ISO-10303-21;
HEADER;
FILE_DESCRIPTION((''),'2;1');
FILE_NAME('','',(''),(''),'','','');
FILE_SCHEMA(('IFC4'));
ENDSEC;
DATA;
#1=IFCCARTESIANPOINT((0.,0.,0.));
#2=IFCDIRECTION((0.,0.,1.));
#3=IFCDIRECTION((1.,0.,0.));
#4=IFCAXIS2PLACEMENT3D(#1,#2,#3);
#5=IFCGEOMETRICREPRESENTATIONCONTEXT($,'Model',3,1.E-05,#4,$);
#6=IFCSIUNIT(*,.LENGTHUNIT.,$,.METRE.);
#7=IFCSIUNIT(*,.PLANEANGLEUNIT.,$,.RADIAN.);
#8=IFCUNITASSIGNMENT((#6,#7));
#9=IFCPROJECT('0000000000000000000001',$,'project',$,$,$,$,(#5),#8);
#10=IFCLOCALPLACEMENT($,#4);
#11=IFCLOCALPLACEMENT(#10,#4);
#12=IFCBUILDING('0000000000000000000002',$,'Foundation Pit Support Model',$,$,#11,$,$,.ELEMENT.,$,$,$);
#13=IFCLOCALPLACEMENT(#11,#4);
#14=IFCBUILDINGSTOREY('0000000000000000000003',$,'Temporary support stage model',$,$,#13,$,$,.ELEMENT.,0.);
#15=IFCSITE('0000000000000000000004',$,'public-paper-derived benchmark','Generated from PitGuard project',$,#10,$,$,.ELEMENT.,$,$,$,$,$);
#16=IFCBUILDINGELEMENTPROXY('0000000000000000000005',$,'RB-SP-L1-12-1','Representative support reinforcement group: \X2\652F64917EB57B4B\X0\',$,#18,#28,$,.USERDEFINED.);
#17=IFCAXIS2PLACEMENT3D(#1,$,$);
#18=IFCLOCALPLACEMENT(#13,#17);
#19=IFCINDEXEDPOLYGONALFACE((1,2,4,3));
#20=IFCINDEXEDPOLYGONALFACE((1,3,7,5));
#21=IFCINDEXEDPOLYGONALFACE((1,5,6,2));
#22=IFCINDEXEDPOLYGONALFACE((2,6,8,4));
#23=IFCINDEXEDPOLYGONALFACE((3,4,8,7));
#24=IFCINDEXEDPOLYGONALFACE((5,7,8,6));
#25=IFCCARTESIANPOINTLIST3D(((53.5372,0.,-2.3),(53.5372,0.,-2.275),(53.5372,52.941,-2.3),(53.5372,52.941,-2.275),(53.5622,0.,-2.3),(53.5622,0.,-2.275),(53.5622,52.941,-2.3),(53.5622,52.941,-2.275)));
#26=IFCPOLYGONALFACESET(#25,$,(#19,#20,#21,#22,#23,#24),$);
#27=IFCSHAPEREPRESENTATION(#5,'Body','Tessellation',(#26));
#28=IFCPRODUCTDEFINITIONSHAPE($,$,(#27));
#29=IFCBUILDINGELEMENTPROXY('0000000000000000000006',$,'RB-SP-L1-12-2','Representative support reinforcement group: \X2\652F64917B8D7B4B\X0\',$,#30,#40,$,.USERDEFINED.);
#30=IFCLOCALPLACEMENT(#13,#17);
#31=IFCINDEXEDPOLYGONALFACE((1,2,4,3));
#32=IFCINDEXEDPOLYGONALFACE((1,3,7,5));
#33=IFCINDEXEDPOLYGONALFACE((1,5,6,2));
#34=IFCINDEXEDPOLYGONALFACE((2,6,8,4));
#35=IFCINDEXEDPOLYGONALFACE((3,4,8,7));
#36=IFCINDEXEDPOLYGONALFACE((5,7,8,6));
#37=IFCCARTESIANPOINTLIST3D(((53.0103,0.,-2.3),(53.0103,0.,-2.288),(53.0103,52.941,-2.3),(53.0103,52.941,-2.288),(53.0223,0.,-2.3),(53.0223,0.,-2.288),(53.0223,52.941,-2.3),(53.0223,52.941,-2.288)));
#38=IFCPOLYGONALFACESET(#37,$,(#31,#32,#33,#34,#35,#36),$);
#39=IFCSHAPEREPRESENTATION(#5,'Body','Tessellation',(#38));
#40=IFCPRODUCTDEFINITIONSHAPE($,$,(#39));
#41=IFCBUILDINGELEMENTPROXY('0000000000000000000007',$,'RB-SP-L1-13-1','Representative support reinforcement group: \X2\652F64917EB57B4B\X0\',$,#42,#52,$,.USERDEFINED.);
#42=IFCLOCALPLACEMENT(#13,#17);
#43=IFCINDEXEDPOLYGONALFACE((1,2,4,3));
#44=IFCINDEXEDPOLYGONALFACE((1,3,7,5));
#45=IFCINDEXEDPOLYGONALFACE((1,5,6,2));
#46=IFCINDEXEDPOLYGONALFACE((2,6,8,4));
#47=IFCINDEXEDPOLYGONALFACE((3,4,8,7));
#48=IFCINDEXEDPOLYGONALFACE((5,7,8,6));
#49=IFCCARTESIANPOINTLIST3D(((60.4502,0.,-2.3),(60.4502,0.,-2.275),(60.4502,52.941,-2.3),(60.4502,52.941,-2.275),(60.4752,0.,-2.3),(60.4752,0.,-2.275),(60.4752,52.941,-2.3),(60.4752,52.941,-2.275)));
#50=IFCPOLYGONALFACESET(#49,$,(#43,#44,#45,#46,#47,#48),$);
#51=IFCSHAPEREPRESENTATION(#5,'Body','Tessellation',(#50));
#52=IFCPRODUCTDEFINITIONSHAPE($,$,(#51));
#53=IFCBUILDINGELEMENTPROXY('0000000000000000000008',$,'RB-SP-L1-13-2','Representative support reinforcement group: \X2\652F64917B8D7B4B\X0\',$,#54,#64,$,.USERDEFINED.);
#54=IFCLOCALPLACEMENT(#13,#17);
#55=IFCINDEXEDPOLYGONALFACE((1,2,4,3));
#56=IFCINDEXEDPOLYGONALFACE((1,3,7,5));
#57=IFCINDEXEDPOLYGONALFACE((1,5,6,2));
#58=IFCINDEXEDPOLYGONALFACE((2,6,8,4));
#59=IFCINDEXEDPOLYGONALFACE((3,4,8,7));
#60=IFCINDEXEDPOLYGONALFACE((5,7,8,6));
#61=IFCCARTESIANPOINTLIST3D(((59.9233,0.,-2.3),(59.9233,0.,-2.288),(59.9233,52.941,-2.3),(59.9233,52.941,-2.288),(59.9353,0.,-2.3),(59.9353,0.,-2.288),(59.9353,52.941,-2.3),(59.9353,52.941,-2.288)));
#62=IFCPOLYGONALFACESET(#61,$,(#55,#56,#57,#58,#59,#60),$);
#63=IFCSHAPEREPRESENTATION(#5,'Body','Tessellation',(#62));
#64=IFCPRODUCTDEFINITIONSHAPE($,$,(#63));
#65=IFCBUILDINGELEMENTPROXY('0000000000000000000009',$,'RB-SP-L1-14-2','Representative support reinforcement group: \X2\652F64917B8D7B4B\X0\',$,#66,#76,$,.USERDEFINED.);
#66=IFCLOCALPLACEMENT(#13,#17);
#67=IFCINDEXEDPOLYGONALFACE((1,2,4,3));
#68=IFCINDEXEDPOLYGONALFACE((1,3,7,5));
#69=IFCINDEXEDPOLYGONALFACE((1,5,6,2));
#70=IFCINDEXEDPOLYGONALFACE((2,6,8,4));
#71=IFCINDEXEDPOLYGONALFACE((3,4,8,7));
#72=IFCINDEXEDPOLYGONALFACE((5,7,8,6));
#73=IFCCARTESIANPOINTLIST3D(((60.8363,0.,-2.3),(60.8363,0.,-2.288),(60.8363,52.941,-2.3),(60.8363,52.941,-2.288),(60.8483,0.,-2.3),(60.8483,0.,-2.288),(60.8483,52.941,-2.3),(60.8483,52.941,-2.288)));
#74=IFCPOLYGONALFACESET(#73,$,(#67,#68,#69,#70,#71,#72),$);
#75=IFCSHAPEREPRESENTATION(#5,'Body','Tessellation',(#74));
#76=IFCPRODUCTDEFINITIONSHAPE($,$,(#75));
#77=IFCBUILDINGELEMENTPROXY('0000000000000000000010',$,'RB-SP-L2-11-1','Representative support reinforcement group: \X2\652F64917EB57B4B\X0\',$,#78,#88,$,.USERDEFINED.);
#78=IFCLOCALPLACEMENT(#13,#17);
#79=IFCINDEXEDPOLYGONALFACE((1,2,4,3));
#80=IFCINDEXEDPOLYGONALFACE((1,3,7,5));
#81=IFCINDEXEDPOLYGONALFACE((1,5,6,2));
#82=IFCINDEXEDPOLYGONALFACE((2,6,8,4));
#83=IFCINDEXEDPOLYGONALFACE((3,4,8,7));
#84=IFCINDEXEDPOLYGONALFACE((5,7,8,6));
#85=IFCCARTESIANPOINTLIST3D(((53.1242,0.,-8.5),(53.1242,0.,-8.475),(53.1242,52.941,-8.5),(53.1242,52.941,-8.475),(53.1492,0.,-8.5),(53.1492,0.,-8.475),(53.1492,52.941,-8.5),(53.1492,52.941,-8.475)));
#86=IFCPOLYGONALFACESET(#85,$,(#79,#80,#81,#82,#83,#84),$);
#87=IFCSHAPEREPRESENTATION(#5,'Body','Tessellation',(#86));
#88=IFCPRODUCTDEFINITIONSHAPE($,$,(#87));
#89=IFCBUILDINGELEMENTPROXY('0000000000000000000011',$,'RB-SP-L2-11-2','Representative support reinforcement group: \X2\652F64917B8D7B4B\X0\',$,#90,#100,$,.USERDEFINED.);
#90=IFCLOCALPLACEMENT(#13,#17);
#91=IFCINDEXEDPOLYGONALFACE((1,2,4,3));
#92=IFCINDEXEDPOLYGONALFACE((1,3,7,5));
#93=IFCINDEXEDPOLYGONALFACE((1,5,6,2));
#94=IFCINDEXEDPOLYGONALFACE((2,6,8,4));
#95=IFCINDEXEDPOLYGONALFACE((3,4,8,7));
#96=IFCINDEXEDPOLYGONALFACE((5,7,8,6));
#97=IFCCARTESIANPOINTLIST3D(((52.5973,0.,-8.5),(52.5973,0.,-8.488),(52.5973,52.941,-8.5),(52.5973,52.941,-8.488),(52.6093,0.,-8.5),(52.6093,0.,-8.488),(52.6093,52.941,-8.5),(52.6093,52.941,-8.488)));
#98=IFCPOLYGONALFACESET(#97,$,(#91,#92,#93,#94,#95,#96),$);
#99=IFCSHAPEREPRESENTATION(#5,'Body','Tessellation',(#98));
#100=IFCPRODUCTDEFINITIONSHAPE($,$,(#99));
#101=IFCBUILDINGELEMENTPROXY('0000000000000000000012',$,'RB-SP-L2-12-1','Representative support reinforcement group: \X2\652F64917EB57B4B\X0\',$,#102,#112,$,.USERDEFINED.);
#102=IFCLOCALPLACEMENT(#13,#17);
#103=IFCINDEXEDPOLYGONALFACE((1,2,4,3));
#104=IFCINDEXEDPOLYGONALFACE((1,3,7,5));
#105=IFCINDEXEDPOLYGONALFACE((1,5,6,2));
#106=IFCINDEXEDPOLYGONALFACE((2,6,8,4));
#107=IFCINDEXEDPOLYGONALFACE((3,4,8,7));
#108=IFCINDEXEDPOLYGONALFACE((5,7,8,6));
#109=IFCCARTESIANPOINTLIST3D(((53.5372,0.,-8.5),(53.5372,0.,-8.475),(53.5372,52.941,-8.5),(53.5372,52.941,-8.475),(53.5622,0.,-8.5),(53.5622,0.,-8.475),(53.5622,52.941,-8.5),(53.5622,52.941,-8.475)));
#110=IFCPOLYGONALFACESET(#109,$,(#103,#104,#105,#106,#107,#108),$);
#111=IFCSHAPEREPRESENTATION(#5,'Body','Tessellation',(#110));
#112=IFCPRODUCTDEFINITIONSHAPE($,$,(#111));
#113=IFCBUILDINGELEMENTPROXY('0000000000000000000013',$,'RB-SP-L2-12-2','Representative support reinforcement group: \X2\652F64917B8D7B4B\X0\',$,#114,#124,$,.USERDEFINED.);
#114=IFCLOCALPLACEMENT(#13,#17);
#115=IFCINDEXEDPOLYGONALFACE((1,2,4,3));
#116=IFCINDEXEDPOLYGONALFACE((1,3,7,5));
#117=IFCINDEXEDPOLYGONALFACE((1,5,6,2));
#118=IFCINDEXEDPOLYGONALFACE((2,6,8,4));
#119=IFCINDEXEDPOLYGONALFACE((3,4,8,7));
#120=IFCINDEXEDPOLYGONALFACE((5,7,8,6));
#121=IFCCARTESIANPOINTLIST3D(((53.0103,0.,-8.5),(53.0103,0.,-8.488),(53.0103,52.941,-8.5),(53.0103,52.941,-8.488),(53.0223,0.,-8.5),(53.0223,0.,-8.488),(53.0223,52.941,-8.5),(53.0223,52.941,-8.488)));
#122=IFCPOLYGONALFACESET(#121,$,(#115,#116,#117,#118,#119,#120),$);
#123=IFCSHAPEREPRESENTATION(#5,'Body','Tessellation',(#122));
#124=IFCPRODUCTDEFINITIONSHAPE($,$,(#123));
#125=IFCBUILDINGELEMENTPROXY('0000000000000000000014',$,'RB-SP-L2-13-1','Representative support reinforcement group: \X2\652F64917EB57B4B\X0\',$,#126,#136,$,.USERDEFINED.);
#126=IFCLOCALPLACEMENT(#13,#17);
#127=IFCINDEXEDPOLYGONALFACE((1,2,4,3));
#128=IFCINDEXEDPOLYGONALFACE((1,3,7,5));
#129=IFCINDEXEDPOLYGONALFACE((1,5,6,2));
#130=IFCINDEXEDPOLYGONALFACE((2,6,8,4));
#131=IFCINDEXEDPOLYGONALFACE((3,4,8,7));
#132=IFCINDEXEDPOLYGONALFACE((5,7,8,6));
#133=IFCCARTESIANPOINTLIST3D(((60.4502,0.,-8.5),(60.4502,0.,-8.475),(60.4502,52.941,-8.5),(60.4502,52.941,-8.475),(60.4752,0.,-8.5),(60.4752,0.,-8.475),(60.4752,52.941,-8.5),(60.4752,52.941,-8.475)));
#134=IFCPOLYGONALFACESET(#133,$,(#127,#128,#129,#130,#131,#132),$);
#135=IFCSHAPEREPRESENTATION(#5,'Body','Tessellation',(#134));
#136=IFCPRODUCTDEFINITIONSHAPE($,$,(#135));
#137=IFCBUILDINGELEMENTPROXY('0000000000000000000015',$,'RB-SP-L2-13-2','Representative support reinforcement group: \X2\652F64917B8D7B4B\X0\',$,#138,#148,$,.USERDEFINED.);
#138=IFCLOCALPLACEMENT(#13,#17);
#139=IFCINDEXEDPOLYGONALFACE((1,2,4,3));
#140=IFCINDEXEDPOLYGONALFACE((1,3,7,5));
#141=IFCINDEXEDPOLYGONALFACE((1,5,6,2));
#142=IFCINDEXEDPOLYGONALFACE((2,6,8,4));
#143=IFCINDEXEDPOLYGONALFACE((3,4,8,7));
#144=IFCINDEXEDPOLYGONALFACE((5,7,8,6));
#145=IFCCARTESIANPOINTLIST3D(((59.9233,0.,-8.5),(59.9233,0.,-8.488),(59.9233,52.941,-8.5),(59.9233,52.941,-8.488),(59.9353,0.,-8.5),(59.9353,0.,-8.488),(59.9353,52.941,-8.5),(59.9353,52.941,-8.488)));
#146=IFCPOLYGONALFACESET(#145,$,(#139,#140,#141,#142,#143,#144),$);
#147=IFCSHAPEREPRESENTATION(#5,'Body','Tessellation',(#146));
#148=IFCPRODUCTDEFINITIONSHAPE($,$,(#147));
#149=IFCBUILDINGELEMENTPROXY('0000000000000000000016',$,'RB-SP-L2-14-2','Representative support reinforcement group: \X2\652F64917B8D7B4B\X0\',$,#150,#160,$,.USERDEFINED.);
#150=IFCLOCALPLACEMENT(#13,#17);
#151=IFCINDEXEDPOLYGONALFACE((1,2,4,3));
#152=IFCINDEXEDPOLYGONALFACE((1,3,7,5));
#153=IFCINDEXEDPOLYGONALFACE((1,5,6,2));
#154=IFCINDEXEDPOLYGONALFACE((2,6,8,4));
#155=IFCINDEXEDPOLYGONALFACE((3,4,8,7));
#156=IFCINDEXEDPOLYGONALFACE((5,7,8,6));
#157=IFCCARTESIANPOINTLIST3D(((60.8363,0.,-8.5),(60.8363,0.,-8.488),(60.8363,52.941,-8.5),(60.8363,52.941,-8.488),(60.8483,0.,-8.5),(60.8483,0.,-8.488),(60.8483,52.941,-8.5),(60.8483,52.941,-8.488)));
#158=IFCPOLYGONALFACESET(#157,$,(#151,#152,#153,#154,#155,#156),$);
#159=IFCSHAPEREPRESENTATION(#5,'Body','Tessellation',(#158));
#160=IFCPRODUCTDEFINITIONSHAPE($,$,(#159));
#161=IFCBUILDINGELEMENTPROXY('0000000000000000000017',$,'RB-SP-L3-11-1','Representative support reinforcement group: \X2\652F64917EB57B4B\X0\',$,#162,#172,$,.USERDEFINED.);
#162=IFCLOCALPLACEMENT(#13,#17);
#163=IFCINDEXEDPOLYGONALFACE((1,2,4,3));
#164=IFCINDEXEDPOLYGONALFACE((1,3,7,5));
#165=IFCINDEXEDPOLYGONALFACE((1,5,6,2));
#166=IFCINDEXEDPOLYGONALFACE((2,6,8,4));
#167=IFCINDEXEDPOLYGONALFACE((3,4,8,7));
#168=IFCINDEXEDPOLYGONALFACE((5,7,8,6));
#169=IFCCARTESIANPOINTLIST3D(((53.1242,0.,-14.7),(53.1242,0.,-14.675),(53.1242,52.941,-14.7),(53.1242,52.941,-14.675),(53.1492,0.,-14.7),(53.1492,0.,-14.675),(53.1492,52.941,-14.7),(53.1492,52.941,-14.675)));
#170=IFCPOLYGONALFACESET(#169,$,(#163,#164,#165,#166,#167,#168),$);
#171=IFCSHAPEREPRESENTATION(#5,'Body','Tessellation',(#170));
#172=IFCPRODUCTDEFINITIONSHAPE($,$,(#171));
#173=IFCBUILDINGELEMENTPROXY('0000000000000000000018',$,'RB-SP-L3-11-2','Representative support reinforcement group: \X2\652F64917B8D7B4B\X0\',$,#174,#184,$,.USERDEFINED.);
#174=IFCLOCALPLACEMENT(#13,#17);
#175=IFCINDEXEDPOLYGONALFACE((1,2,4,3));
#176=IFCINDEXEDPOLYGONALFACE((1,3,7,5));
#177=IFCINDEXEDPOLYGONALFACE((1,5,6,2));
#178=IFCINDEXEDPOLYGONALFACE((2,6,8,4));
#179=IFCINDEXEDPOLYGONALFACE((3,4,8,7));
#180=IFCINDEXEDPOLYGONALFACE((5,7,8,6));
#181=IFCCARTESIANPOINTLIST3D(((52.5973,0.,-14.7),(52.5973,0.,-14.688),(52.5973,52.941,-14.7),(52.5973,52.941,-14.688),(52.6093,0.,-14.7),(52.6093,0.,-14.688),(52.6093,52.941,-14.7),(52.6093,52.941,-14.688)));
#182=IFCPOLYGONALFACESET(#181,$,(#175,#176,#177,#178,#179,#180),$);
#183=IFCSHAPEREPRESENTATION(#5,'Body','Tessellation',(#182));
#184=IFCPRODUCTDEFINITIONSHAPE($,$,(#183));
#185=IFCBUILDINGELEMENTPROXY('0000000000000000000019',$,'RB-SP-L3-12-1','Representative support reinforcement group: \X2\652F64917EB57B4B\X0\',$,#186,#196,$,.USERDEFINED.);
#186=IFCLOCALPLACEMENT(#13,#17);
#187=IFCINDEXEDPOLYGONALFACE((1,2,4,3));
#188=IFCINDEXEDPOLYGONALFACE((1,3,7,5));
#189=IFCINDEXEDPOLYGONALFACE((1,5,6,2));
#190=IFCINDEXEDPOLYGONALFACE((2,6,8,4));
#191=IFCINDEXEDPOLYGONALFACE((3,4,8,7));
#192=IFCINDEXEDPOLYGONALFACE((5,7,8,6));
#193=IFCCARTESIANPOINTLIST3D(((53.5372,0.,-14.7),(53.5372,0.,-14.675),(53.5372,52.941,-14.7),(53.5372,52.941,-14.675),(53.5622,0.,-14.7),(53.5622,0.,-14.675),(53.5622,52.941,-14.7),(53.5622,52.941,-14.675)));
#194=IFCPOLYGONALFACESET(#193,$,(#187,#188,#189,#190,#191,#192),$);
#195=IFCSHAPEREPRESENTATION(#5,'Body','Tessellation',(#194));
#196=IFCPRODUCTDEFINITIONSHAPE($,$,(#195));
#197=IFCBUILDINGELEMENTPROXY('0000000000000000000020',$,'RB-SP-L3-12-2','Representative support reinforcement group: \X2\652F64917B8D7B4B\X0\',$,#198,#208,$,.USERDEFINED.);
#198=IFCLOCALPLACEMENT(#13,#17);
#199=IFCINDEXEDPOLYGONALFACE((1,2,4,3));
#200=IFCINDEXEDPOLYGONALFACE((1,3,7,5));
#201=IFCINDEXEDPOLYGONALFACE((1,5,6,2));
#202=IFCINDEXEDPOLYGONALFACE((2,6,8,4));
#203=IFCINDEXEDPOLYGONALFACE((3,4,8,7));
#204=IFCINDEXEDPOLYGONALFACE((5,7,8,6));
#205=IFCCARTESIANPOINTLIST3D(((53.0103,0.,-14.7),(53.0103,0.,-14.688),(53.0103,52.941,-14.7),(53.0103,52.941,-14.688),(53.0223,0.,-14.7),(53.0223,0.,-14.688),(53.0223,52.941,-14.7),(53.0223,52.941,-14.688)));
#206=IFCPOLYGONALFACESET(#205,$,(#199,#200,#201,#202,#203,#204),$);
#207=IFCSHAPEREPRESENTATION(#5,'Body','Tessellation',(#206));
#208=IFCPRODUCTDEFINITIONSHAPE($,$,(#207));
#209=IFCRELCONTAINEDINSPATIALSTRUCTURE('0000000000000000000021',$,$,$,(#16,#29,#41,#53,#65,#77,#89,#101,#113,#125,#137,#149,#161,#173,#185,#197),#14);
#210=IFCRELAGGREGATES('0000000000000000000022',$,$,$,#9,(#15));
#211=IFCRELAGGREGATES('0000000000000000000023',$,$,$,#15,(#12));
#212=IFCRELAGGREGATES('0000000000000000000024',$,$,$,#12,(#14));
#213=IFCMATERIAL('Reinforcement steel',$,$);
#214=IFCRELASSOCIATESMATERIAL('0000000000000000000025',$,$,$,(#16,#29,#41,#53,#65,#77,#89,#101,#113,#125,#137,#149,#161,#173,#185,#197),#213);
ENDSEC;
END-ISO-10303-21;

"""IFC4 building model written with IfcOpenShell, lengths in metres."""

from ifc_helpers import new_model, si_unit, frame, origin_with_axes, origin_2d, place, context, project, spatial, rectangle, extrude, material, element, save


model = new_model("IFC4")

# Units and contexts
model_context = context("Model", 3, precision=1e-05, world=origin_with_axes())
ifc_project = project(units=[si_unit("LENGTHUNIT", "METRE"), si_unit("PLANEANGLEUNIT", "RADIAN")], contexts=[model_context])

# Site, building, storey
site_placement = place(None, origin_with_axes())
site = spatial("IfcSite", under=ifc_project, at=site_placement, Name="public-paper-derived benchmark", Description="Generated from PitGuard project", CompositionType="ELEMENT")
building_placement = place(site_placement, origin_with_axes())
building = spatial("IfcBuilding", under=site, at=building_placement, Name="Foundation Pit Support Model", CompositionType="ELEMENT")
storey_placement = place(building_placement, origin_with_axes())
storey = spatial("IfcBuildingStorey", under=building, at=storey_placement, Name="Temporary support stage model", CompositionType="ELEMENT", Elevation=0.0)

# Building element proxies
ifc_material_1 = material(Name="Reinforcement steel")
proxy_1_placement = place(storey_placement, frame((53.5497, 26.4705, -2.3), z_axis=(0.0, 0.0, 1.0), x_axis=(0.0, 1.0, 0.0)))
element("IfcBuildingElementProxy", 1, at=proxy_1_placement, inside=storey, material=ifc_material_1, Name="RB-SP-L1-12-1", Description="Representative support reinforcement group: 支撑纵筋", PredefinedType="USERDEFINED", context=model_context, shape_type="SweptSolid", body=[
    extrude(rectangle(XDim=52.941, YDim=0.025, at=origin_2d()), origin_with_axes(), (0.0, 0.0, 1.0), 0.025),
])
proxy_2_placement = place(storey_placement, frame((53.0163, 26.4705, -2.3), z_axis=(0.0, 0.0, 1.0), x_axis=(0.0, 1.0, 0.0)))
element("IfcBuildingElementProxy", 2, at=proxy_2_placement, inside=storey, material=ifc_material_1, Name="RB-SP-L1-12-2", Description="Representative support reinforcement group: 支撑箍筋", PredefinedType="USERDEFINED", context=model_context, shape_type="SweptSolid", body=[
    extrude(rectangle(XDim=52.941, YDim=0.012, at=origin_2d()), origin_with_axes(), (0.0, 0.0, 1.0), 0.012),
])
proxy_3_placement = place(storey_placement, frame((60.4627, 26.4705, -2.3), z_axis=(0.0, 0.0, 1.0), x_axis=(0.0, 1.0, 0.0)))
element("IfcBuildingElementProxy", 3, at=proxy_3_placement, inside=storey, material=ifc_material_1, Name="RB-SP-L1-13-1", Description="Representative support reinforcement group: 支撑纵筋", PredefinedType="USERDEFINED", context=model_context, shape_type="SweptSolid", body=[
    extrude(rectangle(XDim=52.941, YDim=0.025, at=origin_2d()), origin_with_axes(), (0.0, 0.0, 1.0), 0.025),
])
for number, where, z_axis, x_axis, name in (
    (4, (59.9293, 26.4705, -2.3), (0.0, 0.0, 1.0), (0.0, 1.0, 0.0), "RB-SP-L1-13-2"),
    (5, (60.8423, 26.4705, -2.3), (0.0, 0.0, 1.0), (0.0, 1.0, 0.0), "RB-SP-L1-14-2"),
):
    element("IfcBuildingElementProxy", number, at=place(storey_placement, frame(where, z_axis=z_axis, x_axis=x_axis)), inside=storey, material=ifc_material_1, Name=name, Description="Representative support reinforcement group: 支撑箍筋", PredefinedType="USERDEFINED", context=model_context, shape_type="SweptSolid", body=[
        extrude(rectangle(XDim=52.941, YDim=0.012, at=origin_2d()), origin_with_axes(), (0.0, 0.0, 1.0), 0.012),
    ])
proxy_4_placement = place(storey_placement, frame((53.1367, 26.4705, -8.5), z_axis=(0.0, 0.0, 1.0), x_axis=(0.0, 1.0, 0.0)))
element("IfcBuildingElementProxy", 6, at=proxy_4_placement, inside=storey, material=ifc_material_1, Name="RB-SP-L2-11-1", Description="Representative support reinforcement group: 支撑纵筋", PredefinedType="USERDEFINED", context=model_context, shape_type="SweptSolid", body=[
    extrude(rectangle(XDim=52.941, YDim=0.025, at=origin_2d()), origin_with_axes(), (0.0, 0.0, 1.0), 0.025),
])
proxy_5_placement = place(storey_placement, frame((52.6033, 26.4705, -8.5), z_axis=(0.0, 0.0, 1.0), x_axis=(0.0, 1.0, 0.0)))
element("IfcBuildingElementProxy", 7, at=proxy_5_placement, inside=storey, material=ifc_material_1, Name="RB-SP-L2-11-2", Description="Representative support reinforcement group: 支撑箍筋", PredefinedType="USERDEFINED", context=model_context, shape_type="SweptSolid", body=[
    extrude(rectangle(XDim=52.941, YDim=0.012, at=origin_2d()), origin_with_axes(), (0.0, 0.0, 1.0), 0.012),
])
proxy_6_placement = place(storey_placement, frame((53.5497, 26.4705, -8.5), z_axis=(0.0, 0.0, 1.0), x_axis=(0.0, 1.0, 0.0)))
element("IfcBuildingElementProxy", 8, at=proxy_6_placement, inside=storey, material=ifc_material_1, Name="RB-SP-L2-12-1", Description="Representative support reinforcement group: 支撑纵筋", PredefinedType="USERDEFINED", context=model_context, shape_type="SweptSolid", body=[
    extrude(rectangle(XDim=52.941, YDim=0.025, at=origin_2d()), origin_with_axes(), (0.0, 0.0, 1.0), 0.025),
])
proxy_7_placement = place(storey_placement, frame((53.0163, 26.4705, -8.5), z_axis=(0.0, 0.0, 1.0), x_axis=(0.0, 1.0, 0.0)))
element("IfcBuildingElementProxy", 9, at=proxy_7_placement, inside=storey, material=ifc_material_1, Name="RB-SP-L2-12-2", Description="Representative support reinforcement group: 支撑箍筋", PredefinedType="USERDEFINED", context=model_context, shape_type="SweptSolid", body=[
    extrude(rectangle(XDim=52.941, YDim=0.012, at=origin_2d()), origin_with_axes(), (0.0, 0.0, 1.0), 0.012),
])
proxy_8_placement = place(storey_placement, frame((60.4627, 26.4705, -8.5), z_axis=(0.0, 0.0, 1.0), x_axis=(0.0, 1.0, 0.0)))
element("IfcBuildingElementProxy", 10, at=proxy_8_placement, inside=storey, material=ifc_material_1, Name="RB-SP-L2-13-1", Description="Representative support reinforcement group: 支撑纵筋", PredefinedType="USERDEFINED", context=model_context, shape_type="SweptSolid", body=[
    extrude(rectangle(XDim=52.941, YDim=0.025, at=origin_2d()), origin_with_axes(), (0.0, 0.0, 1.0), 0.025),
])
for number, where, z_axis, x_axis, name in (
    (11, (59.9293, 26.4705, -8.5), (0.0, 0.0, 1.0), (0.0, 1.0, 0.0), "RB-SP-L2-13-2"),
    (12, (60.8423, 26.4705, -8.5), (0.0, 0.0, 1.0), (0.0, 1.0, 0.0), "RB-SP-L2-14-2"),
):
    element("IfcBuildingElementProxy", number, at=place(storey_placement, frame(where, z_axis=z_axis, x_axis=x_axis)), inside=storey, material=ifc_material_1, Name=name, Description="Representative support reinforcement group: 支撑箍筋", PredefinedType="USERDEFINED", context=model_context, shape_type="SweptSolid", body=[
        extrude(rectangle(XDim=52.941, YDim=0.012, at=origin_2d()), origin_with_axes(), (0.0, 0.0, 1.0), 0.012),
    ])
proxy_9_placement = place(storey_placement, frame((53.1367, 26.4705, -14.7), z_axis=(0.0, 0.0, 1.0), x_axis=(0.0, 1.0, 0.0)))
element("IfcBuildingElementProxy", 13, at=proxy_9_placement, inside=storey, material=ifc_material_1, Name="RB-SP-L3-11-1", Description="Representative support reinforcement group: 支撑纵筋", PredefinedType="USERDEFINED", context=model_context, shape_type="SweptSolid", body=[
    extrude(rectangle(XDim=52.941, YDim=0.025, at=origin_2d()), origin_with_axes(), (0.0, 0.0, 1.0), 0.025),
])
proxy_10_placement = place(storey_placement, frame((52.6033, 26.4705, -14.7), z_axis=(0.0, 0.0, 1.0), x_axis=(0.0, 1.0, 0.0)))
element("IfcBuildingElementProxy", 14, at=proxy_10_placement, inside=storey, material=ifc_material_1, Name="RB-SP-L3-11-2", Description="Representative support reinforcement group: 支撑箍筋", PredefinedType="USERDEFINED", context=model_context, shape_type="SweptSolid", body=[
    extrude(rectangle(XDim=52.941, YDim=0.012, at=origin_2d()), origin_with_axes(), (0.0, 0.0, 1.0), 0.012),
])
proxy_11_placement = place(storey_placement, frame((53.5497, 26.4705, -14.7), z_axis=(0.0, 0.0, 1.0), x_axis=(0.0, 1.0, 0.0)))
element("IfcBuildingElementProxy", 15, at=proxy_11_placement, inside=storey, material=ifc_material_1, Name="RB-SP-L3-12-1", Description="Representative support reinforcement group: 支撑纵筋", PredefinedType="USERDEFINED", context=model_context, shape_type="SweptSolid", body=[
    extrude(rectangle(XDim=52.941, YDim=0.025, at=origin_2d()), origin_with_axes(), (0.0, 0.0, 1.0), 0.025),
])
proxy_12_placement = place(storey_placement, frame((53.0163, 26.4705, -14.7), z_axis=(0.0, 0.0, 1.0), x_axis=(0.0, 1.0, 0.0)))
element("IfcBuildingElementProxy", 16, at=proxy_12_placement, inside=storey, material=ifc_material_1, Name="RB-SP-L3-12-2", Description="Representative support reinforcement group: 支撑箍筋", PredefinedType="USERDEFINED", context=model_context, shape_type="SweptSolid", body=[
    extrude(rectangle(XDim=52.941, YDim=0.012, at=origin_2d()), origin_with_axes(), (0.0, 0.0, 1.0), 0.012),
])

save(model, "model.ifc")
